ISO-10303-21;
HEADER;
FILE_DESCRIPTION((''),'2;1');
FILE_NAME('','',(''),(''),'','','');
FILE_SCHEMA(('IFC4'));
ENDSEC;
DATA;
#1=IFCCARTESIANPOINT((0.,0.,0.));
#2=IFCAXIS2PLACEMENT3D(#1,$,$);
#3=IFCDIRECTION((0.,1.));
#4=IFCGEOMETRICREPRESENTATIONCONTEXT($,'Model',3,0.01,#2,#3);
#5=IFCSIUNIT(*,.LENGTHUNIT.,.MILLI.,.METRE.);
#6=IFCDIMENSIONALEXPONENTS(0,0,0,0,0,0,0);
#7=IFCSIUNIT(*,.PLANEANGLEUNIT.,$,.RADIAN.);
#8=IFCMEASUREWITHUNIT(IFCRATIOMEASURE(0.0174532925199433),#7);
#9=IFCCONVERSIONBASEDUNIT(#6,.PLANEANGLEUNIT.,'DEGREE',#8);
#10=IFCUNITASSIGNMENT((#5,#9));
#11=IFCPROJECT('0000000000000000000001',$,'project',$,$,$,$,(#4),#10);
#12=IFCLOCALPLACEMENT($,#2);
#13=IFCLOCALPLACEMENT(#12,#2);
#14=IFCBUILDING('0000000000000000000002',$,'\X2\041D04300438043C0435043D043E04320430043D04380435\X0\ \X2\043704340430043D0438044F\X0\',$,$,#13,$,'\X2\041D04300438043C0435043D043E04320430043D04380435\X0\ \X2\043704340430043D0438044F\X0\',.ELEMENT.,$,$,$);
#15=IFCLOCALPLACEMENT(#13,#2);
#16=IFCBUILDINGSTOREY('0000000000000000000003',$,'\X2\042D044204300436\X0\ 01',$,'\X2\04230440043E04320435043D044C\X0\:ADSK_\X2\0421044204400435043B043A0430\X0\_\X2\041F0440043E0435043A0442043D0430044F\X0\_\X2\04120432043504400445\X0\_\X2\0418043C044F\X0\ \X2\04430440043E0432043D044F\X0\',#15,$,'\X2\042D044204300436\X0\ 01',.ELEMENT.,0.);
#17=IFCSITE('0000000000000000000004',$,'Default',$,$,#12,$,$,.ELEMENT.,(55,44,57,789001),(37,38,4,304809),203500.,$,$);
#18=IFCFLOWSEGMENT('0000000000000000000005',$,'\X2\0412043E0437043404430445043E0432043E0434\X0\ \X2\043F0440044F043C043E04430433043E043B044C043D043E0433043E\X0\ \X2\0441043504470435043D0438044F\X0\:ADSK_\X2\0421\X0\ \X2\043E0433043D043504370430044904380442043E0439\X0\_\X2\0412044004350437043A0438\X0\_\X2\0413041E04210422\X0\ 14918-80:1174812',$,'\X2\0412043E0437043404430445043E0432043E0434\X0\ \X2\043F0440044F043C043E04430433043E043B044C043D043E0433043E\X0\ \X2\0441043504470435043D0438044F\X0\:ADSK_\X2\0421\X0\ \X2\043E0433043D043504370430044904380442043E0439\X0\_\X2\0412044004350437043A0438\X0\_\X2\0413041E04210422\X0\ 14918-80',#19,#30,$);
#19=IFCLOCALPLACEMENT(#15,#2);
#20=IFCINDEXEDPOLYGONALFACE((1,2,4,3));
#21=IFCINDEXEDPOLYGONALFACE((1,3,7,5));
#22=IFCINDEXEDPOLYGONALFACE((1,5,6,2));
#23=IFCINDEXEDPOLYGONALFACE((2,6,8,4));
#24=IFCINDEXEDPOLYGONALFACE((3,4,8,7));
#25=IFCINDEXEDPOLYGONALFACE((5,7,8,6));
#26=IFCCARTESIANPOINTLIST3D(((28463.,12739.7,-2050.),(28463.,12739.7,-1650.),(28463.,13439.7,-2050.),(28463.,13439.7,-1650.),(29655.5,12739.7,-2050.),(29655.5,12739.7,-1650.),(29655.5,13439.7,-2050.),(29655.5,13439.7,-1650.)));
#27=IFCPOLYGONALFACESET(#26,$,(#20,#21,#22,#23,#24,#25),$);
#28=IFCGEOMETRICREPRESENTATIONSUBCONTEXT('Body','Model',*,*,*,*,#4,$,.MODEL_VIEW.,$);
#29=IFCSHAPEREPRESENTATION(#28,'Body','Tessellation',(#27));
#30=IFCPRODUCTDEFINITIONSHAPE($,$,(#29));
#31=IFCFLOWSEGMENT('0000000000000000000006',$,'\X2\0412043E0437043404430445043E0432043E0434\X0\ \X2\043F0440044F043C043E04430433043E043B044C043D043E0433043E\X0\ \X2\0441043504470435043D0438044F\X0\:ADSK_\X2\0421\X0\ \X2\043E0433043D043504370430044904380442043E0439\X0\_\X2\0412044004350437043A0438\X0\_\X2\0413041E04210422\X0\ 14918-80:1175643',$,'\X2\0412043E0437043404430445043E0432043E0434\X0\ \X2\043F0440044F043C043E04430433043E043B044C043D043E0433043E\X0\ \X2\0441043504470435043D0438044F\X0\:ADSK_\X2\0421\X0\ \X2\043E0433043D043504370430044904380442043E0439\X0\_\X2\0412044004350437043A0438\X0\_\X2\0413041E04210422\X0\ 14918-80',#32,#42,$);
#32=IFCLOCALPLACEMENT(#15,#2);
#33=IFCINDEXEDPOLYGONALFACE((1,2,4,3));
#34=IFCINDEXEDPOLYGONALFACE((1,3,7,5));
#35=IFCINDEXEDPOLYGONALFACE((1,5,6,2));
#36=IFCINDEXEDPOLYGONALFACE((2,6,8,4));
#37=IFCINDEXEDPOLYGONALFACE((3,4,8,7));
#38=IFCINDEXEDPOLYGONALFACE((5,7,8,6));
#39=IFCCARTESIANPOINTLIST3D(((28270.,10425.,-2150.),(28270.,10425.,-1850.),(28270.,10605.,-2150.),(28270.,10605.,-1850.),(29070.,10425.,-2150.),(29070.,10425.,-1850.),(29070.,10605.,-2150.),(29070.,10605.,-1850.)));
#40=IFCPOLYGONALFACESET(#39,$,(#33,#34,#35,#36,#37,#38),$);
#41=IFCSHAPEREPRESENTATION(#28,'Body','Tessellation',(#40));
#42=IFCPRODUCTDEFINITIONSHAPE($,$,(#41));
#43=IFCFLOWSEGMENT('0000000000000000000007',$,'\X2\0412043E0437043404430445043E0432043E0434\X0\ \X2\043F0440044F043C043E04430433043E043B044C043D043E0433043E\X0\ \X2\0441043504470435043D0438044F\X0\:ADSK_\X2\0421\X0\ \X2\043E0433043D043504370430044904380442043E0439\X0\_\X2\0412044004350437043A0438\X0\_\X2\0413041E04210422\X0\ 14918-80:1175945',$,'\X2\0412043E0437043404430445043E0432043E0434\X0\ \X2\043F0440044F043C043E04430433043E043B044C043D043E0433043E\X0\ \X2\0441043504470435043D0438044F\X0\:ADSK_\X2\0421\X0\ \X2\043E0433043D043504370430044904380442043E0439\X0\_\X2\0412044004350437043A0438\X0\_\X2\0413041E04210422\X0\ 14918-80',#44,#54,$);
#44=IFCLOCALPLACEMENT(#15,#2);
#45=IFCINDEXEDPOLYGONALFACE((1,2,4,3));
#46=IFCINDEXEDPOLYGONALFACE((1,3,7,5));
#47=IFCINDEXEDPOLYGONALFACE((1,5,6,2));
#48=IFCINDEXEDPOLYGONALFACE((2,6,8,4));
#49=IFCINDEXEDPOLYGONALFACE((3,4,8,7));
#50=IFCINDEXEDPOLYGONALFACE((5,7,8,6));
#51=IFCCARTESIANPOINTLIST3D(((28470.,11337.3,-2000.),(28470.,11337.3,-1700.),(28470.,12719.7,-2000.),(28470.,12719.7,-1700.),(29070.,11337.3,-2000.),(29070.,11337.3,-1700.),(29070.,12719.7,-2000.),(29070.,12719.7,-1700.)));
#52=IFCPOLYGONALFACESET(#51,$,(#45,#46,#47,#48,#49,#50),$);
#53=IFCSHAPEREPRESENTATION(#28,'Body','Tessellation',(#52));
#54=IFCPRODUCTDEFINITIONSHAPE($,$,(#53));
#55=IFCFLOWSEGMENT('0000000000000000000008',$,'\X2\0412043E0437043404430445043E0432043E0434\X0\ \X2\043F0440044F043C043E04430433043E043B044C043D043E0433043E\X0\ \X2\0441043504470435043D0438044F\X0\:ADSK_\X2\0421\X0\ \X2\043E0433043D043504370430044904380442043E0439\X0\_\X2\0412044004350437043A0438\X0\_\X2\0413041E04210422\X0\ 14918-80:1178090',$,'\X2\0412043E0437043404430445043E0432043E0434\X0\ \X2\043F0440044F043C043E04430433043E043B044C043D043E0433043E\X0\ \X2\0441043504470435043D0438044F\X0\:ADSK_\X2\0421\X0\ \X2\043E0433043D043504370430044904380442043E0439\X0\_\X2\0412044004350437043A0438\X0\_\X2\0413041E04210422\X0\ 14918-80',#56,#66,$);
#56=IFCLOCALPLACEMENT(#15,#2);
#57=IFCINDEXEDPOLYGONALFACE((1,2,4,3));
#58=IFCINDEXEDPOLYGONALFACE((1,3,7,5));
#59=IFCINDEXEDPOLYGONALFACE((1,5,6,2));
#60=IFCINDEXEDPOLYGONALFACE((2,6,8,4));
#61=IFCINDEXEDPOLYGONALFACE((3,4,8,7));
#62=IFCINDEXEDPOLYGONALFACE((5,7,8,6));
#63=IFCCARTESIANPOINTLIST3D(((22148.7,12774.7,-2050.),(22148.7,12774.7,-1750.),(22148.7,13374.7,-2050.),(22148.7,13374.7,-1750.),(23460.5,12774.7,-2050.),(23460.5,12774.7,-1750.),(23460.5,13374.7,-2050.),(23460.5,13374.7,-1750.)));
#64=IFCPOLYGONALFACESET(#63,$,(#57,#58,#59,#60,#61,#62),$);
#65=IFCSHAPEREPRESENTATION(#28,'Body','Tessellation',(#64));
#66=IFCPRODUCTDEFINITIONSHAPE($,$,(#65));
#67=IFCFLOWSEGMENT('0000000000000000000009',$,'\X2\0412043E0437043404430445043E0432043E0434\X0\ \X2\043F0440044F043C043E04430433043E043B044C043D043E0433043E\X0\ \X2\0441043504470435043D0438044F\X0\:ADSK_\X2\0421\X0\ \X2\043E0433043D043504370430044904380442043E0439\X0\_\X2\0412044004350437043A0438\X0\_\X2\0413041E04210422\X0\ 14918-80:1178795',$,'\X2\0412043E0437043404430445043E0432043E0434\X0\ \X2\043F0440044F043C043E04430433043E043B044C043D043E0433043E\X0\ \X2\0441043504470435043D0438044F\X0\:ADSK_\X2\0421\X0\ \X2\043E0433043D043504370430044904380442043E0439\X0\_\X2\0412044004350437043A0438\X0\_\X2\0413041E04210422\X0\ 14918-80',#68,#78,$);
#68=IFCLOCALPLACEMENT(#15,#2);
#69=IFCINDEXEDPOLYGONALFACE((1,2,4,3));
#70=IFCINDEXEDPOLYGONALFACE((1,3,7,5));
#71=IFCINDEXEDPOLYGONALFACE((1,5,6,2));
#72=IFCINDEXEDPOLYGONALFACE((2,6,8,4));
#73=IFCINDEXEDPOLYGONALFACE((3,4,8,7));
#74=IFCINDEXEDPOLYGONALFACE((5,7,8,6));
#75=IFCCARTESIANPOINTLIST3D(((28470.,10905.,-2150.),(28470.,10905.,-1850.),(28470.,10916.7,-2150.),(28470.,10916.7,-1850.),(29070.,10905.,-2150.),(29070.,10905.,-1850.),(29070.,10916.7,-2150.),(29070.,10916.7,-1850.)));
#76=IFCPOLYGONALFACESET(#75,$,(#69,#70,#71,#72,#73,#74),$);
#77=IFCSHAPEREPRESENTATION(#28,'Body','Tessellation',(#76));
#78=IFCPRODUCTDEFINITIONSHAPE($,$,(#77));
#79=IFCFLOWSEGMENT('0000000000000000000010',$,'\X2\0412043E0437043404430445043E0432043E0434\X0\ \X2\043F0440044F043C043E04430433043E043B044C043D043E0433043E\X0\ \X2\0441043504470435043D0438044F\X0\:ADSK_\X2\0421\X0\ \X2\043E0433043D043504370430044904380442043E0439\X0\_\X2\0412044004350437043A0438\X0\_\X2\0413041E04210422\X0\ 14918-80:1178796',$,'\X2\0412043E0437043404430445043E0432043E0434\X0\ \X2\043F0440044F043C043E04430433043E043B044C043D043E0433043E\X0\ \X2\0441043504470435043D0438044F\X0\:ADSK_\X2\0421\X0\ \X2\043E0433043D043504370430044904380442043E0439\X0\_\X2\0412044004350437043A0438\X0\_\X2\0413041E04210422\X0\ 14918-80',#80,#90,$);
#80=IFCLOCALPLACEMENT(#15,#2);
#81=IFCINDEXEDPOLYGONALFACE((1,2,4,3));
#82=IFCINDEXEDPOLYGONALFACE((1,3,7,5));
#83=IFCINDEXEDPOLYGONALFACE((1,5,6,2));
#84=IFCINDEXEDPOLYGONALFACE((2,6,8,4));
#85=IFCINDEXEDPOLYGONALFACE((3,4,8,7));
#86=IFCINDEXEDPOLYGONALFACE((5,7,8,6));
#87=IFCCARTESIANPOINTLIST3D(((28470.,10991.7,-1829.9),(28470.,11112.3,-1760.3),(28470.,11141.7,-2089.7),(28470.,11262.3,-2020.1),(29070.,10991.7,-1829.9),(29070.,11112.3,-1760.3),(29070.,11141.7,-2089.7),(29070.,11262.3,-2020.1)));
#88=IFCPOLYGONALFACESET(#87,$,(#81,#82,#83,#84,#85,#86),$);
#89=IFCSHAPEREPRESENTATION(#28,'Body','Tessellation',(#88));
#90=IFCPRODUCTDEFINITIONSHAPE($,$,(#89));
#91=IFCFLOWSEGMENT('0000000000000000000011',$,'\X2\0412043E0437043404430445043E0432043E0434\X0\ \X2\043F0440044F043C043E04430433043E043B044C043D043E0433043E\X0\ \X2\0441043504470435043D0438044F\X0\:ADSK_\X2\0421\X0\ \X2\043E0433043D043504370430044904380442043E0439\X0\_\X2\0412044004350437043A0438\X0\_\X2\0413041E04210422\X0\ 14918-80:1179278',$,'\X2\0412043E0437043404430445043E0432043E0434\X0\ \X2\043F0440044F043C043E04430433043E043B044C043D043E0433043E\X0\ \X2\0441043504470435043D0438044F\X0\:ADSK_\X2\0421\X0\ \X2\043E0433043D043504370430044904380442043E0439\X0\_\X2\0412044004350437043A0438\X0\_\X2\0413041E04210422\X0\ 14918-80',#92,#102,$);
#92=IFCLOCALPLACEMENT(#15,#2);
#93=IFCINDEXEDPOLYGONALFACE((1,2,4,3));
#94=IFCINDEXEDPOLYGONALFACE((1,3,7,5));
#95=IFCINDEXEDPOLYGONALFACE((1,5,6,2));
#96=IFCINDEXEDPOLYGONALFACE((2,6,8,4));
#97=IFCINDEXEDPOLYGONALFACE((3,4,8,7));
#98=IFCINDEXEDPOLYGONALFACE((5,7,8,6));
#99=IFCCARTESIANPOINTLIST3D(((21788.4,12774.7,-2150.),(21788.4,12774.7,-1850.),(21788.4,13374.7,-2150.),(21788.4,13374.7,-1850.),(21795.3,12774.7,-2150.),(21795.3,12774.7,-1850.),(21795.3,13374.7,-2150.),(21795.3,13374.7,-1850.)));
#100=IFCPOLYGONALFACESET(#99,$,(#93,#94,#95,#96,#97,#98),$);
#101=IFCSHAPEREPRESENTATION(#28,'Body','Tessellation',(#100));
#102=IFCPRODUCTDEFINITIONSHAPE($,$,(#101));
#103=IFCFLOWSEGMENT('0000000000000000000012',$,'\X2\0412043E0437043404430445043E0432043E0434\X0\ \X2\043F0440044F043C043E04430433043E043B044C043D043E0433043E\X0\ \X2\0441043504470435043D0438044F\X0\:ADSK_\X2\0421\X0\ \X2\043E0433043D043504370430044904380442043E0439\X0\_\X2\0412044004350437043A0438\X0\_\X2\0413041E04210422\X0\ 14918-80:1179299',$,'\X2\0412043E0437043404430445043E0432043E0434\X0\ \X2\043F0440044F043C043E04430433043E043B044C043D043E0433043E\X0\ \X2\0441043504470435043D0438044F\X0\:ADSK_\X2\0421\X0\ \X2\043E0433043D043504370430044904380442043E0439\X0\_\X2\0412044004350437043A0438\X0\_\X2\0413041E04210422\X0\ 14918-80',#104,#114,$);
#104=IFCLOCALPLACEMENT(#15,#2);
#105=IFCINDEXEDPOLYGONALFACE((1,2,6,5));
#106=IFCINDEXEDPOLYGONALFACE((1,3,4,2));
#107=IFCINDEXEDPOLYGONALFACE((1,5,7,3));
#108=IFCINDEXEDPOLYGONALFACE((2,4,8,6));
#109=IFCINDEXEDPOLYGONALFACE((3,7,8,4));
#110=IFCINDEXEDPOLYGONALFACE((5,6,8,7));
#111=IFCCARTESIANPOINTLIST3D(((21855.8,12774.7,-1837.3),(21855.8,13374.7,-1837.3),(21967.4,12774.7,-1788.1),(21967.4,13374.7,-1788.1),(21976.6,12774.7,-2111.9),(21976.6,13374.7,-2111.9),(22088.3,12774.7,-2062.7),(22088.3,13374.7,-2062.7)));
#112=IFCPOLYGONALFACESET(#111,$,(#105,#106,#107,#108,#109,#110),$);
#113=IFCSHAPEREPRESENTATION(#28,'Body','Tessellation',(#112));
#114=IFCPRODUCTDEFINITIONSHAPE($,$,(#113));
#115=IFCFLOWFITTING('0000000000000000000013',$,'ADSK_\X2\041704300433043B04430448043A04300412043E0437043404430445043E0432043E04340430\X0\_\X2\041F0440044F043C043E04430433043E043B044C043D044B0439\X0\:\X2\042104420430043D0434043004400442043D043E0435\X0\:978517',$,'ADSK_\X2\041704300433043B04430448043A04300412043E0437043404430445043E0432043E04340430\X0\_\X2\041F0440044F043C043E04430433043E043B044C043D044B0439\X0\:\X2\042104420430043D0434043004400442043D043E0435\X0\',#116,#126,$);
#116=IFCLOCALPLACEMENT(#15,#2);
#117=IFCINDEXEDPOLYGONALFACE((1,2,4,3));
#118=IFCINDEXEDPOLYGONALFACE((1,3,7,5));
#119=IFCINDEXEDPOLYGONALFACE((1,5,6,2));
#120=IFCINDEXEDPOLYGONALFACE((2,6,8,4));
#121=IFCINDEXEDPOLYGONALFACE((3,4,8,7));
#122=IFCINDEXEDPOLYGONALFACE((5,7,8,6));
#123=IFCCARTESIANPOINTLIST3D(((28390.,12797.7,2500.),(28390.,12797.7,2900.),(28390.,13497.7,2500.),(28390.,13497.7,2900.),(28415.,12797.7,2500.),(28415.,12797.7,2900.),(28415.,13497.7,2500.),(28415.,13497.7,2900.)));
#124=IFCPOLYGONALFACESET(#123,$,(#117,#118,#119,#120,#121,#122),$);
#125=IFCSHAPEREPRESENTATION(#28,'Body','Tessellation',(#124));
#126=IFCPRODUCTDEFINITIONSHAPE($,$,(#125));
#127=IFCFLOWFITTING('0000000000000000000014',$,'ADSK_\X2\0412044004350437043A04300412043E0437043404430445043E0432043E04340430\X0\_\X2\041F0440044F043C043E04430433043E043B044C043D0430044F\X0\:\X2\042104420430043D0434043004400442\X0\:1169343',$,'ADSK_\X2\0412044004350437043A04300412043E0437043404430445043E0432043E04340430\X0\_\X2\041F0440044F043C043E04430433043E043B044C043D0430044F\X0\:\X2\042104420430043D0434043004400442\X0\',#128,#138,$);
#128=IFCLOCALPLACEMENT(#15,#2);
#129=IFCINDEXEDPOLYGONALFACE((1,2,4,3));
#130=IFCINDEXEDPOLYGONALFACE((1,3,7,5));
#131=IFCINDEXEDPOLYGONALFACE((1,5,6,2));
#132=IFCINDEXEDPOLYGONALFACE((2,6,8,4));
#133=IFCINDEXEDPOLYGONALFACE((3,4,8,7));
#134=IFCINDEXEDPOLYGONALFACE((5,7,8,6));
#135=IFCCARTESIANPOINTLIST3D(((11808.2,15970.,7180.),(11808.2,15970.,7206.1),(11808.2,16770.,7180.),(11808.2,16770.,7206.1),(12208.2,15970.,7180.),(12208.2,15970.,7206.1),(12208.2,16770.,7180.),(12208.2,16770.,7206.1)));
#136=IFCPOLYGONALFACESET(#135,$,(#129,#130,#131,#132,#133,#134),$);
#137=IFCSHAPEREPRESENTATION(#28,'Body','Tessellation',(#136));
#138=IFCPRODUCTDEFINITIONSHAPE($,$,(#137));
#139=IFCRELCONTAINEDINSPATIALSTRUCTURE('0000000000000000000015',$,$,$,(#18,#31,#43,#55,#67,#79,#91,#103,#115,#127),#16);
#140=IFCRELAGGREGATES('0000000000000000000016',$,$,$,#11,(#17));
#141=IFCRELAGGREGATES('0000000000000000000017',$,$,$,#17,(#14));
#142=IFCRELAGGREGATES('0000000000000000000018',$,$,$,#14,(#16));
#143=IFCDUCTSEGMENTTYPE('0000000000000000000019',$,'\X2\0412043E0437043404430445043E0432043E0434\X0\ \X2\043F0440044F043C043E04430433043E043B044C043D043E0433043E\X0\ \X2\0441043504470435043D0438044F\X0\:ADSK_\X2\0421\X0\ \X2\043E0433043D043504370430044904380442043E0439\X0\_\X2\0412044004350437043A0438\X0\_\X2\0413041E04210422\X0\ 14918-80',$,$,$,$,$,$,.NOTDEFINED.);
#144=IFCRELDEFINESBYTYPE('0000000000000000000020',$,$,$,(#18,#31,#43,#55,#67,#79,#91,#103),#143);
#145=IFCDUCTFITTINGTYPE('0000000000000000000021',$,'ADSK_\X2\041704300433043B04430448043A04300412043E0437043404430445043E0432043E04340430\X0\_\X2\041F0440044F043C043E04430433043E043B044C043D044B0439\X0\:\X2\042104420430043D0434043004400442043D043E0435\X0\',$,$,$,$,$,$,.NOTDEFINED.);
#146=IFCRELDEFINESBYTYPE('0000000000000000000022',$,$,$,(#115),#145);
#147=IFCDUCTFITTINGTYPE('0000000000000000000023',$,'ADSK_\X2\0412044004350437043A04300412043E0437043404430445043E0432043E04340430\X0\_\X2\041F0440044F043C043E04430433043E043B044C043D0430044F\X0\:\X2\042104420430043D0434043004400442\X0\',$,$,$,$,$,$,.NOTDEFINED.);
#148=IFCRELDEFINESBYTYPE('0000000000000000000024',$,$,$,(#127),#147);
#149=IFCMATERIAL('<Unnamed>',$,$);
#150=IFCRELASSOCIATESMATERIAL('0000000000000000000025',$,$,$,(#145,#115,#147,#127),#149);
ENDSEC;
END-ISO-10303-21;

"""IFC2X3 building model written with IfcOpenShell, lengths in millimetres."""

from ifc_helpers import new_model, entity, si_unit, converted_unit, direction, frame, frame_2d, origin, origin_2d_with_axis, place, context, subcontext, project, spatial, rectangle, extrude, source, transform, mapped, material, type_object, type_shapes, element, save


model = new_model("IFC2X3")

# Units and contexts
model_context = context("Model", 3, precision=0.01, world=origin(), true_north=direction((0.0, 1.0)))
body_context = subcontext(model_context, "Body", "Model", "MODEL_VIEW")
ifc_project = project(units=[si_unit("LENGTHUNIT", "METRE", prefix="MILLI"), converted_unit("PLANEANGLEUNIT", "DEGREE", entity("IfcRatioMeasure", 0.0174532925199433), si_unit("PLANEANGLEUNIT", "RADIAN"), dimensions=[0, 0, 0, 0, 0, 0, 0])], contexts=[model_context])

# Site, building, storey
site_placement = place(None, frame((0.0, 0.0, 0.0)))
site = spatial("IfcSite", under=ifc_project, at=site_placement, Name="Default", CompositionType="ELEMENT", RefLatitude=(55, 44, 57, 789001), RefLongitude=(37, 38, 4, 304809), RefElevation=203500.0)
building_placement = place(site_placement, origin())
building = spatial("IfcBuilding", under=site, at=building_placement, Name="Наименование здания", LongName="Наименование здания", CompositionType="ELEMENT")
storey_placement = place(building_placement, origin())
storey = spatial("IfcBuildingStorey", under=building, at=storey_placement, Name="Этаж 01", ObjectType="Уровень:ADSK_Стрелка_Проектная_Вверх_Имя уровня", LongName="Этаж 01", CompositionType="ELEMENT", Elevation=0.0)

# Flow segments
duct_segment_type = type_object("IfcDuctSegmentType", Name="Воздуховод прямоугольного сечения:ADSK_С огнезащитой_Врезки_ГОСТ 14918-80", PredefinedType="NOTDEFINED")
flow_segment_1_placement = place(storey_placement, frame((28463.0, 12739.7, -2050.0)))
element("IfcFlowSegment", 1, at=flow_segment_1_placement, inside=storey, type_object=duct_segment_type, Name="Воздуховод прямоугольного сечения:ADSK_С огнезащитой_Врезки_ГОСТ 14918-80:1174812", ObjectType="Воздуховод прямоугольного сечения:ADSK_С огнезащитой_Врезки_ГОСТ 14918-80", context=body_context, shape_type="SweptSolid", body=[
    extrude(rectangle(XDim=1192.5, YDim=700.0, at=frame_2d((0.0, 0.0), x_axis=(1.0, 0.0))), frame((596.3, 350.0, 0.0), z_axis=(0.0, 0.0, 1.0), x_axis=(-1.0, 0.0, 0.0)), (0.0, 0.0, 1.0), 400.0),
])
flow_segment_2_placement = place(storey_placement, frame((28270.0, 10425.0, -2150.0)))
element("IfcFlowSegment", 2, at=flow_segment_2_placement, inside=storey, type_object=duct_segment_type, Name="Воздуховод прямоугольного сечения:ADSK_С огнезащитой_Врезки_ГОСТ 14918-80:1175643", ObjectType="Воздуховод прямоугольного сечения:ADSK_С огнезащитой_Врезки_ГОСТ 14918-80", context=body_context, shape_type="SweptSolid", body=[
    extrude(rectangle(XDim=180.0, YDim=800.0, at=frame_2d((0.0, 0.0), x_axis=(1.0, 0.0))), frame((400.0, 90.0, 0.0), z_axis=(0.0, 0.0, 1.0), x_axis=(0.0, -1.0, 0.0)), (0.0, 0.0, 1.0), 300.0),
])
flow_segment_3_placement = place(storey_placement, frame((28470.0, 11337.3, -2000.0)))
element("IfcFlowSegment", 3, at=flow_segment_3_placement, inside=storey, type_object=duct_segment_type, Name="Воздуховод прямоугольного сечения:ADSK_С огнезащитой_Врезки_ГОСТ 14918-80:1175945", ObjectType="Воздуховод прямоугольного сечения:ADSK_С огнезащитой_Врезки_ГОСТ 14918-80", context=body_context, shape_type="SweptSolid", body=[
    extrude(rectangle(XDim=1382.4, YDim=600.0, at=frame_2d((0.0, 0.0), x_axis=(1.0, 0.0))), frame((300.0, 691.2, 0.0), z_axis=(0.0, 0.0, 1.0), x_axis=(0.0, -1.0, 0.0)), (0.0, 0.0, 1.0), 300.0),
])
flow_segment_4_placement = place(storey_placement, frame((22148.7, 12774.7, -2050.0)))
element("IfcFlowSegment", 4, at=flow_segment_4_placement, inside=storey, type_object=duct_segment_type, Name="Воздуховод прямоугольного сечения:ADSK_С огнезащитой_Врезки_ГОСТ 14918-80:1178090", ObjectType="Воздуховод прямоугольного сечения:ADSK_С огнезащитой_Врезки_ГОСТ 14918-80", context=body_context, shape_type="SweptSolid", body=[
    extrude(rectangle(XDim=1311.8, YDim=600.0, at=frame_2d((0.0, 0.0), x_axis=(1.0, 0.0))), frame((655.9, 300.0, 0.0)), (0.0, 0.0, 1.0), 300.0),
])
flow_segment_5_placement = place(storey_placement, frame((28470.0, 10905.0, -2150.0)))
element("IfcFlowSegment", 5, at=flow_segment_5_placement, inside=storey, type_object=duct_segment_type, Name="Воздуховод прямоугольного сечения:ADSK_С огнезащитой_Врезки_ГОСТ 14918-80:1178795", ObjectType="Воздуховод прямоугольного сечения:ADSK_С огнезащитой_Врезки_ГОСТ 14918-80", context=body_context, shape_type="SweptSolid", body=[
    extrude(rectangle(XDim=11.7, YDim=600.0, at=frame_2d((0.0, 0.0), x_axis=(1.0, 0.0))), frame((300.0, 5.9, 0.0), z_axis=(0.0, 0.0, 1.0), x_axis=(0.0, 1.0, 0.0)), (0.0, 0.0, 1.0), 300.0),
])
flow_segment_6_placement = place(storey_placement, frame((28470.0, 10991.7, -2089.7)))
element("IfcFlowSegment", 6, at=flow_segment_6_placement, inside=storey, type_object=duct_segment_type, Name="Воздуховод прямоугольного сечения:ADSK_С огнезащитой_Врезки_ГОСТ 14918-80:1178796", ObjectType="Воздуховод прямоугольного сечения:ADSK_С огнезащитой_Врезки_ГОСТ 14918-80", context=body_context, shape_type="SweptSolid", body=[
    extrude(rectangle(XDim=300.0, YDim=139.2, at=frame_2d((0.0, 0.0), x_axis=(0.0, 1.0))), frame((0.0, 135.3, 164.7), z_axis=(1.0, 0.0, 0.0), x_axis=(0.0, 0.866025, 0.5)), (0.0, 0.0, 1.0), 600.0),
])
flow_segment_7_placement = place(storey_placement, frame((21788.4, 12774.7, -2150.0)))
element("IfcFlowSegment", 7, at=flow_segment_7_placement, inside=storey, type_object=duct_segment_type, Name="Воздуховод прямоугольного сечения:ADSK_С огнезащитой_Врезки_ГОСТ 14918-80:1179278", ObjectType="Воздуховод прямоугольного сечения:ADSK_С огнезащитой_Врезки_ГОСТ 14918-80", context=body_context, shape_type="SweptSolid", body=[
    extrude(rectangle(XDim=6.9, YDim=600.0, at=frame_2d((0.0, 0.0), x_axis=(1.0, 0.0))), frame((3.4, 300.0, 0.0)), (0.0, 0.0, 1.0), 300.0),
])
flow_segment_8_placement = place(storey_placement, frame((21855.8, 12774.7, -2111.9)))
element("IfcFlowSegment", 8, at=flow_segment_8_placement, inside=storey, type_object=duct_segment_type, Name="Воздуховод прямоугольного сечения:ADSK_С огнезащитой_Врезки_ГОСТ 14918-80:1179299", ObjectType="Воздуховод прямоугольного сечения:ADSK_С огнезащитой_Врезки_ГОСТ 14918-80", context=body_context, shape_type="SweptSolid", body=[
    extrude(rectangle(XDim=300.0, YDim=122.0, at=frame_2d((0.0, 0.0), x_axis=(0.0, 1.0))), frame((116.2, 0.0, 161.9), z_axis=(0.0, 1.0, 0.0), x_axis=(-0.915232, 0.0, -0.402928)), (0.0, 0.0, 1.0), 600.0),
])

# Flow fittings
ifc_material = material(Name="<Unnamed>")
duct_fitting_type_1 = type_object("IfcDuctFittingType", Name="ADSK_ЗаглушкаВоздуховода_Прямоугольный:Стандартное", PredefinedType="NOTDEFINED", material=ifc_material)
shared_shape_1 = source(origin(), body_context, "Body", "SweptSolid", [
    extrude(rectangle(XDim=25.0, YDim=700.0, at=frame_2d((0.0, 0.0), x_axis=(1.0, 0.0))), frame((12.5, 0.0, -200.0)), (0.0, 0.0, 1.0), 400.0),
])
type_shapes(duct_fitting_type_1, [shared_shape_1])
flow_fitting_1_placement = place(storey_placement, frame((28415.0, 13147.7, 2700.0), z_axis=(0.0, 0.0, 1.0), x_axis=(-1.0, 0.0, 0.0)))
element("IfcFlowFitting", 9, at=flow_fitting_1_placement, inside=storey, type_object=duct_fitting_type_1, material=ifc_material, Name="ADSK_ЗаглушкаВоздуховода_Прямоугольный:Стандартное:978517", ObjectType="ADSK_ЗаглушкаВоздуховода_Прямоугольный:Стандартное", context=body_context, shape_type="MappedRepresentation", body=[
    mapped(shared_shape_1, transform((0.0, 0.0, 0.0), scale=1.0)),
])
duct_fitting_type_2 = type_object("IfcDuctFittingType", Name="ADSK_ВрезкаВоздуховода_Прямоугольная:Стандарт", PredefinedType="NOTDEFINED", material=ifc_material)
shared_shape_2 = source(origin(), body_context, "Body", "SweptSolid", [
    extrude(rectangle(XDim=400.0, YDim=26.1, at=origin_2d_with_axis()), frame((7.0, 0.0, -400.0), z_axis=(0.0, 0.0, 1.0), x_axis=(0.0, -1.0, 0.0)), (0.0, 0.0, 1.0), 800.0),
])
type_shapes(duct_fitting_type_2, [shared_shape_2])
flow_fitting_2_placement = place(storey_placement, frame((12008.2, 16370.0, 7200.0), z_axis=(0.0, 1.0, 0.0), x_axis=(0.0, 0.0, -1.0)))
element("IfcFlowFitting", 10, at=flow_fitting_2_placement, inside=storey, type_object=duct_fitting_type_2, material=ifc_material, Name="ADSK_ВрезкаВоздуховода_Прямоугольная:Стандарт:1169343", ObjectType="ADSK_ВрезкаВоздуховода_Прямоугольная:Стандарт", context=body_context, shape_type="MappedRepresentation", body=[
    mapped(shared_shape_2, transform((0.0, 0.0, 0.0), scale=1.0)),
])

save(model, "model.ifc")
